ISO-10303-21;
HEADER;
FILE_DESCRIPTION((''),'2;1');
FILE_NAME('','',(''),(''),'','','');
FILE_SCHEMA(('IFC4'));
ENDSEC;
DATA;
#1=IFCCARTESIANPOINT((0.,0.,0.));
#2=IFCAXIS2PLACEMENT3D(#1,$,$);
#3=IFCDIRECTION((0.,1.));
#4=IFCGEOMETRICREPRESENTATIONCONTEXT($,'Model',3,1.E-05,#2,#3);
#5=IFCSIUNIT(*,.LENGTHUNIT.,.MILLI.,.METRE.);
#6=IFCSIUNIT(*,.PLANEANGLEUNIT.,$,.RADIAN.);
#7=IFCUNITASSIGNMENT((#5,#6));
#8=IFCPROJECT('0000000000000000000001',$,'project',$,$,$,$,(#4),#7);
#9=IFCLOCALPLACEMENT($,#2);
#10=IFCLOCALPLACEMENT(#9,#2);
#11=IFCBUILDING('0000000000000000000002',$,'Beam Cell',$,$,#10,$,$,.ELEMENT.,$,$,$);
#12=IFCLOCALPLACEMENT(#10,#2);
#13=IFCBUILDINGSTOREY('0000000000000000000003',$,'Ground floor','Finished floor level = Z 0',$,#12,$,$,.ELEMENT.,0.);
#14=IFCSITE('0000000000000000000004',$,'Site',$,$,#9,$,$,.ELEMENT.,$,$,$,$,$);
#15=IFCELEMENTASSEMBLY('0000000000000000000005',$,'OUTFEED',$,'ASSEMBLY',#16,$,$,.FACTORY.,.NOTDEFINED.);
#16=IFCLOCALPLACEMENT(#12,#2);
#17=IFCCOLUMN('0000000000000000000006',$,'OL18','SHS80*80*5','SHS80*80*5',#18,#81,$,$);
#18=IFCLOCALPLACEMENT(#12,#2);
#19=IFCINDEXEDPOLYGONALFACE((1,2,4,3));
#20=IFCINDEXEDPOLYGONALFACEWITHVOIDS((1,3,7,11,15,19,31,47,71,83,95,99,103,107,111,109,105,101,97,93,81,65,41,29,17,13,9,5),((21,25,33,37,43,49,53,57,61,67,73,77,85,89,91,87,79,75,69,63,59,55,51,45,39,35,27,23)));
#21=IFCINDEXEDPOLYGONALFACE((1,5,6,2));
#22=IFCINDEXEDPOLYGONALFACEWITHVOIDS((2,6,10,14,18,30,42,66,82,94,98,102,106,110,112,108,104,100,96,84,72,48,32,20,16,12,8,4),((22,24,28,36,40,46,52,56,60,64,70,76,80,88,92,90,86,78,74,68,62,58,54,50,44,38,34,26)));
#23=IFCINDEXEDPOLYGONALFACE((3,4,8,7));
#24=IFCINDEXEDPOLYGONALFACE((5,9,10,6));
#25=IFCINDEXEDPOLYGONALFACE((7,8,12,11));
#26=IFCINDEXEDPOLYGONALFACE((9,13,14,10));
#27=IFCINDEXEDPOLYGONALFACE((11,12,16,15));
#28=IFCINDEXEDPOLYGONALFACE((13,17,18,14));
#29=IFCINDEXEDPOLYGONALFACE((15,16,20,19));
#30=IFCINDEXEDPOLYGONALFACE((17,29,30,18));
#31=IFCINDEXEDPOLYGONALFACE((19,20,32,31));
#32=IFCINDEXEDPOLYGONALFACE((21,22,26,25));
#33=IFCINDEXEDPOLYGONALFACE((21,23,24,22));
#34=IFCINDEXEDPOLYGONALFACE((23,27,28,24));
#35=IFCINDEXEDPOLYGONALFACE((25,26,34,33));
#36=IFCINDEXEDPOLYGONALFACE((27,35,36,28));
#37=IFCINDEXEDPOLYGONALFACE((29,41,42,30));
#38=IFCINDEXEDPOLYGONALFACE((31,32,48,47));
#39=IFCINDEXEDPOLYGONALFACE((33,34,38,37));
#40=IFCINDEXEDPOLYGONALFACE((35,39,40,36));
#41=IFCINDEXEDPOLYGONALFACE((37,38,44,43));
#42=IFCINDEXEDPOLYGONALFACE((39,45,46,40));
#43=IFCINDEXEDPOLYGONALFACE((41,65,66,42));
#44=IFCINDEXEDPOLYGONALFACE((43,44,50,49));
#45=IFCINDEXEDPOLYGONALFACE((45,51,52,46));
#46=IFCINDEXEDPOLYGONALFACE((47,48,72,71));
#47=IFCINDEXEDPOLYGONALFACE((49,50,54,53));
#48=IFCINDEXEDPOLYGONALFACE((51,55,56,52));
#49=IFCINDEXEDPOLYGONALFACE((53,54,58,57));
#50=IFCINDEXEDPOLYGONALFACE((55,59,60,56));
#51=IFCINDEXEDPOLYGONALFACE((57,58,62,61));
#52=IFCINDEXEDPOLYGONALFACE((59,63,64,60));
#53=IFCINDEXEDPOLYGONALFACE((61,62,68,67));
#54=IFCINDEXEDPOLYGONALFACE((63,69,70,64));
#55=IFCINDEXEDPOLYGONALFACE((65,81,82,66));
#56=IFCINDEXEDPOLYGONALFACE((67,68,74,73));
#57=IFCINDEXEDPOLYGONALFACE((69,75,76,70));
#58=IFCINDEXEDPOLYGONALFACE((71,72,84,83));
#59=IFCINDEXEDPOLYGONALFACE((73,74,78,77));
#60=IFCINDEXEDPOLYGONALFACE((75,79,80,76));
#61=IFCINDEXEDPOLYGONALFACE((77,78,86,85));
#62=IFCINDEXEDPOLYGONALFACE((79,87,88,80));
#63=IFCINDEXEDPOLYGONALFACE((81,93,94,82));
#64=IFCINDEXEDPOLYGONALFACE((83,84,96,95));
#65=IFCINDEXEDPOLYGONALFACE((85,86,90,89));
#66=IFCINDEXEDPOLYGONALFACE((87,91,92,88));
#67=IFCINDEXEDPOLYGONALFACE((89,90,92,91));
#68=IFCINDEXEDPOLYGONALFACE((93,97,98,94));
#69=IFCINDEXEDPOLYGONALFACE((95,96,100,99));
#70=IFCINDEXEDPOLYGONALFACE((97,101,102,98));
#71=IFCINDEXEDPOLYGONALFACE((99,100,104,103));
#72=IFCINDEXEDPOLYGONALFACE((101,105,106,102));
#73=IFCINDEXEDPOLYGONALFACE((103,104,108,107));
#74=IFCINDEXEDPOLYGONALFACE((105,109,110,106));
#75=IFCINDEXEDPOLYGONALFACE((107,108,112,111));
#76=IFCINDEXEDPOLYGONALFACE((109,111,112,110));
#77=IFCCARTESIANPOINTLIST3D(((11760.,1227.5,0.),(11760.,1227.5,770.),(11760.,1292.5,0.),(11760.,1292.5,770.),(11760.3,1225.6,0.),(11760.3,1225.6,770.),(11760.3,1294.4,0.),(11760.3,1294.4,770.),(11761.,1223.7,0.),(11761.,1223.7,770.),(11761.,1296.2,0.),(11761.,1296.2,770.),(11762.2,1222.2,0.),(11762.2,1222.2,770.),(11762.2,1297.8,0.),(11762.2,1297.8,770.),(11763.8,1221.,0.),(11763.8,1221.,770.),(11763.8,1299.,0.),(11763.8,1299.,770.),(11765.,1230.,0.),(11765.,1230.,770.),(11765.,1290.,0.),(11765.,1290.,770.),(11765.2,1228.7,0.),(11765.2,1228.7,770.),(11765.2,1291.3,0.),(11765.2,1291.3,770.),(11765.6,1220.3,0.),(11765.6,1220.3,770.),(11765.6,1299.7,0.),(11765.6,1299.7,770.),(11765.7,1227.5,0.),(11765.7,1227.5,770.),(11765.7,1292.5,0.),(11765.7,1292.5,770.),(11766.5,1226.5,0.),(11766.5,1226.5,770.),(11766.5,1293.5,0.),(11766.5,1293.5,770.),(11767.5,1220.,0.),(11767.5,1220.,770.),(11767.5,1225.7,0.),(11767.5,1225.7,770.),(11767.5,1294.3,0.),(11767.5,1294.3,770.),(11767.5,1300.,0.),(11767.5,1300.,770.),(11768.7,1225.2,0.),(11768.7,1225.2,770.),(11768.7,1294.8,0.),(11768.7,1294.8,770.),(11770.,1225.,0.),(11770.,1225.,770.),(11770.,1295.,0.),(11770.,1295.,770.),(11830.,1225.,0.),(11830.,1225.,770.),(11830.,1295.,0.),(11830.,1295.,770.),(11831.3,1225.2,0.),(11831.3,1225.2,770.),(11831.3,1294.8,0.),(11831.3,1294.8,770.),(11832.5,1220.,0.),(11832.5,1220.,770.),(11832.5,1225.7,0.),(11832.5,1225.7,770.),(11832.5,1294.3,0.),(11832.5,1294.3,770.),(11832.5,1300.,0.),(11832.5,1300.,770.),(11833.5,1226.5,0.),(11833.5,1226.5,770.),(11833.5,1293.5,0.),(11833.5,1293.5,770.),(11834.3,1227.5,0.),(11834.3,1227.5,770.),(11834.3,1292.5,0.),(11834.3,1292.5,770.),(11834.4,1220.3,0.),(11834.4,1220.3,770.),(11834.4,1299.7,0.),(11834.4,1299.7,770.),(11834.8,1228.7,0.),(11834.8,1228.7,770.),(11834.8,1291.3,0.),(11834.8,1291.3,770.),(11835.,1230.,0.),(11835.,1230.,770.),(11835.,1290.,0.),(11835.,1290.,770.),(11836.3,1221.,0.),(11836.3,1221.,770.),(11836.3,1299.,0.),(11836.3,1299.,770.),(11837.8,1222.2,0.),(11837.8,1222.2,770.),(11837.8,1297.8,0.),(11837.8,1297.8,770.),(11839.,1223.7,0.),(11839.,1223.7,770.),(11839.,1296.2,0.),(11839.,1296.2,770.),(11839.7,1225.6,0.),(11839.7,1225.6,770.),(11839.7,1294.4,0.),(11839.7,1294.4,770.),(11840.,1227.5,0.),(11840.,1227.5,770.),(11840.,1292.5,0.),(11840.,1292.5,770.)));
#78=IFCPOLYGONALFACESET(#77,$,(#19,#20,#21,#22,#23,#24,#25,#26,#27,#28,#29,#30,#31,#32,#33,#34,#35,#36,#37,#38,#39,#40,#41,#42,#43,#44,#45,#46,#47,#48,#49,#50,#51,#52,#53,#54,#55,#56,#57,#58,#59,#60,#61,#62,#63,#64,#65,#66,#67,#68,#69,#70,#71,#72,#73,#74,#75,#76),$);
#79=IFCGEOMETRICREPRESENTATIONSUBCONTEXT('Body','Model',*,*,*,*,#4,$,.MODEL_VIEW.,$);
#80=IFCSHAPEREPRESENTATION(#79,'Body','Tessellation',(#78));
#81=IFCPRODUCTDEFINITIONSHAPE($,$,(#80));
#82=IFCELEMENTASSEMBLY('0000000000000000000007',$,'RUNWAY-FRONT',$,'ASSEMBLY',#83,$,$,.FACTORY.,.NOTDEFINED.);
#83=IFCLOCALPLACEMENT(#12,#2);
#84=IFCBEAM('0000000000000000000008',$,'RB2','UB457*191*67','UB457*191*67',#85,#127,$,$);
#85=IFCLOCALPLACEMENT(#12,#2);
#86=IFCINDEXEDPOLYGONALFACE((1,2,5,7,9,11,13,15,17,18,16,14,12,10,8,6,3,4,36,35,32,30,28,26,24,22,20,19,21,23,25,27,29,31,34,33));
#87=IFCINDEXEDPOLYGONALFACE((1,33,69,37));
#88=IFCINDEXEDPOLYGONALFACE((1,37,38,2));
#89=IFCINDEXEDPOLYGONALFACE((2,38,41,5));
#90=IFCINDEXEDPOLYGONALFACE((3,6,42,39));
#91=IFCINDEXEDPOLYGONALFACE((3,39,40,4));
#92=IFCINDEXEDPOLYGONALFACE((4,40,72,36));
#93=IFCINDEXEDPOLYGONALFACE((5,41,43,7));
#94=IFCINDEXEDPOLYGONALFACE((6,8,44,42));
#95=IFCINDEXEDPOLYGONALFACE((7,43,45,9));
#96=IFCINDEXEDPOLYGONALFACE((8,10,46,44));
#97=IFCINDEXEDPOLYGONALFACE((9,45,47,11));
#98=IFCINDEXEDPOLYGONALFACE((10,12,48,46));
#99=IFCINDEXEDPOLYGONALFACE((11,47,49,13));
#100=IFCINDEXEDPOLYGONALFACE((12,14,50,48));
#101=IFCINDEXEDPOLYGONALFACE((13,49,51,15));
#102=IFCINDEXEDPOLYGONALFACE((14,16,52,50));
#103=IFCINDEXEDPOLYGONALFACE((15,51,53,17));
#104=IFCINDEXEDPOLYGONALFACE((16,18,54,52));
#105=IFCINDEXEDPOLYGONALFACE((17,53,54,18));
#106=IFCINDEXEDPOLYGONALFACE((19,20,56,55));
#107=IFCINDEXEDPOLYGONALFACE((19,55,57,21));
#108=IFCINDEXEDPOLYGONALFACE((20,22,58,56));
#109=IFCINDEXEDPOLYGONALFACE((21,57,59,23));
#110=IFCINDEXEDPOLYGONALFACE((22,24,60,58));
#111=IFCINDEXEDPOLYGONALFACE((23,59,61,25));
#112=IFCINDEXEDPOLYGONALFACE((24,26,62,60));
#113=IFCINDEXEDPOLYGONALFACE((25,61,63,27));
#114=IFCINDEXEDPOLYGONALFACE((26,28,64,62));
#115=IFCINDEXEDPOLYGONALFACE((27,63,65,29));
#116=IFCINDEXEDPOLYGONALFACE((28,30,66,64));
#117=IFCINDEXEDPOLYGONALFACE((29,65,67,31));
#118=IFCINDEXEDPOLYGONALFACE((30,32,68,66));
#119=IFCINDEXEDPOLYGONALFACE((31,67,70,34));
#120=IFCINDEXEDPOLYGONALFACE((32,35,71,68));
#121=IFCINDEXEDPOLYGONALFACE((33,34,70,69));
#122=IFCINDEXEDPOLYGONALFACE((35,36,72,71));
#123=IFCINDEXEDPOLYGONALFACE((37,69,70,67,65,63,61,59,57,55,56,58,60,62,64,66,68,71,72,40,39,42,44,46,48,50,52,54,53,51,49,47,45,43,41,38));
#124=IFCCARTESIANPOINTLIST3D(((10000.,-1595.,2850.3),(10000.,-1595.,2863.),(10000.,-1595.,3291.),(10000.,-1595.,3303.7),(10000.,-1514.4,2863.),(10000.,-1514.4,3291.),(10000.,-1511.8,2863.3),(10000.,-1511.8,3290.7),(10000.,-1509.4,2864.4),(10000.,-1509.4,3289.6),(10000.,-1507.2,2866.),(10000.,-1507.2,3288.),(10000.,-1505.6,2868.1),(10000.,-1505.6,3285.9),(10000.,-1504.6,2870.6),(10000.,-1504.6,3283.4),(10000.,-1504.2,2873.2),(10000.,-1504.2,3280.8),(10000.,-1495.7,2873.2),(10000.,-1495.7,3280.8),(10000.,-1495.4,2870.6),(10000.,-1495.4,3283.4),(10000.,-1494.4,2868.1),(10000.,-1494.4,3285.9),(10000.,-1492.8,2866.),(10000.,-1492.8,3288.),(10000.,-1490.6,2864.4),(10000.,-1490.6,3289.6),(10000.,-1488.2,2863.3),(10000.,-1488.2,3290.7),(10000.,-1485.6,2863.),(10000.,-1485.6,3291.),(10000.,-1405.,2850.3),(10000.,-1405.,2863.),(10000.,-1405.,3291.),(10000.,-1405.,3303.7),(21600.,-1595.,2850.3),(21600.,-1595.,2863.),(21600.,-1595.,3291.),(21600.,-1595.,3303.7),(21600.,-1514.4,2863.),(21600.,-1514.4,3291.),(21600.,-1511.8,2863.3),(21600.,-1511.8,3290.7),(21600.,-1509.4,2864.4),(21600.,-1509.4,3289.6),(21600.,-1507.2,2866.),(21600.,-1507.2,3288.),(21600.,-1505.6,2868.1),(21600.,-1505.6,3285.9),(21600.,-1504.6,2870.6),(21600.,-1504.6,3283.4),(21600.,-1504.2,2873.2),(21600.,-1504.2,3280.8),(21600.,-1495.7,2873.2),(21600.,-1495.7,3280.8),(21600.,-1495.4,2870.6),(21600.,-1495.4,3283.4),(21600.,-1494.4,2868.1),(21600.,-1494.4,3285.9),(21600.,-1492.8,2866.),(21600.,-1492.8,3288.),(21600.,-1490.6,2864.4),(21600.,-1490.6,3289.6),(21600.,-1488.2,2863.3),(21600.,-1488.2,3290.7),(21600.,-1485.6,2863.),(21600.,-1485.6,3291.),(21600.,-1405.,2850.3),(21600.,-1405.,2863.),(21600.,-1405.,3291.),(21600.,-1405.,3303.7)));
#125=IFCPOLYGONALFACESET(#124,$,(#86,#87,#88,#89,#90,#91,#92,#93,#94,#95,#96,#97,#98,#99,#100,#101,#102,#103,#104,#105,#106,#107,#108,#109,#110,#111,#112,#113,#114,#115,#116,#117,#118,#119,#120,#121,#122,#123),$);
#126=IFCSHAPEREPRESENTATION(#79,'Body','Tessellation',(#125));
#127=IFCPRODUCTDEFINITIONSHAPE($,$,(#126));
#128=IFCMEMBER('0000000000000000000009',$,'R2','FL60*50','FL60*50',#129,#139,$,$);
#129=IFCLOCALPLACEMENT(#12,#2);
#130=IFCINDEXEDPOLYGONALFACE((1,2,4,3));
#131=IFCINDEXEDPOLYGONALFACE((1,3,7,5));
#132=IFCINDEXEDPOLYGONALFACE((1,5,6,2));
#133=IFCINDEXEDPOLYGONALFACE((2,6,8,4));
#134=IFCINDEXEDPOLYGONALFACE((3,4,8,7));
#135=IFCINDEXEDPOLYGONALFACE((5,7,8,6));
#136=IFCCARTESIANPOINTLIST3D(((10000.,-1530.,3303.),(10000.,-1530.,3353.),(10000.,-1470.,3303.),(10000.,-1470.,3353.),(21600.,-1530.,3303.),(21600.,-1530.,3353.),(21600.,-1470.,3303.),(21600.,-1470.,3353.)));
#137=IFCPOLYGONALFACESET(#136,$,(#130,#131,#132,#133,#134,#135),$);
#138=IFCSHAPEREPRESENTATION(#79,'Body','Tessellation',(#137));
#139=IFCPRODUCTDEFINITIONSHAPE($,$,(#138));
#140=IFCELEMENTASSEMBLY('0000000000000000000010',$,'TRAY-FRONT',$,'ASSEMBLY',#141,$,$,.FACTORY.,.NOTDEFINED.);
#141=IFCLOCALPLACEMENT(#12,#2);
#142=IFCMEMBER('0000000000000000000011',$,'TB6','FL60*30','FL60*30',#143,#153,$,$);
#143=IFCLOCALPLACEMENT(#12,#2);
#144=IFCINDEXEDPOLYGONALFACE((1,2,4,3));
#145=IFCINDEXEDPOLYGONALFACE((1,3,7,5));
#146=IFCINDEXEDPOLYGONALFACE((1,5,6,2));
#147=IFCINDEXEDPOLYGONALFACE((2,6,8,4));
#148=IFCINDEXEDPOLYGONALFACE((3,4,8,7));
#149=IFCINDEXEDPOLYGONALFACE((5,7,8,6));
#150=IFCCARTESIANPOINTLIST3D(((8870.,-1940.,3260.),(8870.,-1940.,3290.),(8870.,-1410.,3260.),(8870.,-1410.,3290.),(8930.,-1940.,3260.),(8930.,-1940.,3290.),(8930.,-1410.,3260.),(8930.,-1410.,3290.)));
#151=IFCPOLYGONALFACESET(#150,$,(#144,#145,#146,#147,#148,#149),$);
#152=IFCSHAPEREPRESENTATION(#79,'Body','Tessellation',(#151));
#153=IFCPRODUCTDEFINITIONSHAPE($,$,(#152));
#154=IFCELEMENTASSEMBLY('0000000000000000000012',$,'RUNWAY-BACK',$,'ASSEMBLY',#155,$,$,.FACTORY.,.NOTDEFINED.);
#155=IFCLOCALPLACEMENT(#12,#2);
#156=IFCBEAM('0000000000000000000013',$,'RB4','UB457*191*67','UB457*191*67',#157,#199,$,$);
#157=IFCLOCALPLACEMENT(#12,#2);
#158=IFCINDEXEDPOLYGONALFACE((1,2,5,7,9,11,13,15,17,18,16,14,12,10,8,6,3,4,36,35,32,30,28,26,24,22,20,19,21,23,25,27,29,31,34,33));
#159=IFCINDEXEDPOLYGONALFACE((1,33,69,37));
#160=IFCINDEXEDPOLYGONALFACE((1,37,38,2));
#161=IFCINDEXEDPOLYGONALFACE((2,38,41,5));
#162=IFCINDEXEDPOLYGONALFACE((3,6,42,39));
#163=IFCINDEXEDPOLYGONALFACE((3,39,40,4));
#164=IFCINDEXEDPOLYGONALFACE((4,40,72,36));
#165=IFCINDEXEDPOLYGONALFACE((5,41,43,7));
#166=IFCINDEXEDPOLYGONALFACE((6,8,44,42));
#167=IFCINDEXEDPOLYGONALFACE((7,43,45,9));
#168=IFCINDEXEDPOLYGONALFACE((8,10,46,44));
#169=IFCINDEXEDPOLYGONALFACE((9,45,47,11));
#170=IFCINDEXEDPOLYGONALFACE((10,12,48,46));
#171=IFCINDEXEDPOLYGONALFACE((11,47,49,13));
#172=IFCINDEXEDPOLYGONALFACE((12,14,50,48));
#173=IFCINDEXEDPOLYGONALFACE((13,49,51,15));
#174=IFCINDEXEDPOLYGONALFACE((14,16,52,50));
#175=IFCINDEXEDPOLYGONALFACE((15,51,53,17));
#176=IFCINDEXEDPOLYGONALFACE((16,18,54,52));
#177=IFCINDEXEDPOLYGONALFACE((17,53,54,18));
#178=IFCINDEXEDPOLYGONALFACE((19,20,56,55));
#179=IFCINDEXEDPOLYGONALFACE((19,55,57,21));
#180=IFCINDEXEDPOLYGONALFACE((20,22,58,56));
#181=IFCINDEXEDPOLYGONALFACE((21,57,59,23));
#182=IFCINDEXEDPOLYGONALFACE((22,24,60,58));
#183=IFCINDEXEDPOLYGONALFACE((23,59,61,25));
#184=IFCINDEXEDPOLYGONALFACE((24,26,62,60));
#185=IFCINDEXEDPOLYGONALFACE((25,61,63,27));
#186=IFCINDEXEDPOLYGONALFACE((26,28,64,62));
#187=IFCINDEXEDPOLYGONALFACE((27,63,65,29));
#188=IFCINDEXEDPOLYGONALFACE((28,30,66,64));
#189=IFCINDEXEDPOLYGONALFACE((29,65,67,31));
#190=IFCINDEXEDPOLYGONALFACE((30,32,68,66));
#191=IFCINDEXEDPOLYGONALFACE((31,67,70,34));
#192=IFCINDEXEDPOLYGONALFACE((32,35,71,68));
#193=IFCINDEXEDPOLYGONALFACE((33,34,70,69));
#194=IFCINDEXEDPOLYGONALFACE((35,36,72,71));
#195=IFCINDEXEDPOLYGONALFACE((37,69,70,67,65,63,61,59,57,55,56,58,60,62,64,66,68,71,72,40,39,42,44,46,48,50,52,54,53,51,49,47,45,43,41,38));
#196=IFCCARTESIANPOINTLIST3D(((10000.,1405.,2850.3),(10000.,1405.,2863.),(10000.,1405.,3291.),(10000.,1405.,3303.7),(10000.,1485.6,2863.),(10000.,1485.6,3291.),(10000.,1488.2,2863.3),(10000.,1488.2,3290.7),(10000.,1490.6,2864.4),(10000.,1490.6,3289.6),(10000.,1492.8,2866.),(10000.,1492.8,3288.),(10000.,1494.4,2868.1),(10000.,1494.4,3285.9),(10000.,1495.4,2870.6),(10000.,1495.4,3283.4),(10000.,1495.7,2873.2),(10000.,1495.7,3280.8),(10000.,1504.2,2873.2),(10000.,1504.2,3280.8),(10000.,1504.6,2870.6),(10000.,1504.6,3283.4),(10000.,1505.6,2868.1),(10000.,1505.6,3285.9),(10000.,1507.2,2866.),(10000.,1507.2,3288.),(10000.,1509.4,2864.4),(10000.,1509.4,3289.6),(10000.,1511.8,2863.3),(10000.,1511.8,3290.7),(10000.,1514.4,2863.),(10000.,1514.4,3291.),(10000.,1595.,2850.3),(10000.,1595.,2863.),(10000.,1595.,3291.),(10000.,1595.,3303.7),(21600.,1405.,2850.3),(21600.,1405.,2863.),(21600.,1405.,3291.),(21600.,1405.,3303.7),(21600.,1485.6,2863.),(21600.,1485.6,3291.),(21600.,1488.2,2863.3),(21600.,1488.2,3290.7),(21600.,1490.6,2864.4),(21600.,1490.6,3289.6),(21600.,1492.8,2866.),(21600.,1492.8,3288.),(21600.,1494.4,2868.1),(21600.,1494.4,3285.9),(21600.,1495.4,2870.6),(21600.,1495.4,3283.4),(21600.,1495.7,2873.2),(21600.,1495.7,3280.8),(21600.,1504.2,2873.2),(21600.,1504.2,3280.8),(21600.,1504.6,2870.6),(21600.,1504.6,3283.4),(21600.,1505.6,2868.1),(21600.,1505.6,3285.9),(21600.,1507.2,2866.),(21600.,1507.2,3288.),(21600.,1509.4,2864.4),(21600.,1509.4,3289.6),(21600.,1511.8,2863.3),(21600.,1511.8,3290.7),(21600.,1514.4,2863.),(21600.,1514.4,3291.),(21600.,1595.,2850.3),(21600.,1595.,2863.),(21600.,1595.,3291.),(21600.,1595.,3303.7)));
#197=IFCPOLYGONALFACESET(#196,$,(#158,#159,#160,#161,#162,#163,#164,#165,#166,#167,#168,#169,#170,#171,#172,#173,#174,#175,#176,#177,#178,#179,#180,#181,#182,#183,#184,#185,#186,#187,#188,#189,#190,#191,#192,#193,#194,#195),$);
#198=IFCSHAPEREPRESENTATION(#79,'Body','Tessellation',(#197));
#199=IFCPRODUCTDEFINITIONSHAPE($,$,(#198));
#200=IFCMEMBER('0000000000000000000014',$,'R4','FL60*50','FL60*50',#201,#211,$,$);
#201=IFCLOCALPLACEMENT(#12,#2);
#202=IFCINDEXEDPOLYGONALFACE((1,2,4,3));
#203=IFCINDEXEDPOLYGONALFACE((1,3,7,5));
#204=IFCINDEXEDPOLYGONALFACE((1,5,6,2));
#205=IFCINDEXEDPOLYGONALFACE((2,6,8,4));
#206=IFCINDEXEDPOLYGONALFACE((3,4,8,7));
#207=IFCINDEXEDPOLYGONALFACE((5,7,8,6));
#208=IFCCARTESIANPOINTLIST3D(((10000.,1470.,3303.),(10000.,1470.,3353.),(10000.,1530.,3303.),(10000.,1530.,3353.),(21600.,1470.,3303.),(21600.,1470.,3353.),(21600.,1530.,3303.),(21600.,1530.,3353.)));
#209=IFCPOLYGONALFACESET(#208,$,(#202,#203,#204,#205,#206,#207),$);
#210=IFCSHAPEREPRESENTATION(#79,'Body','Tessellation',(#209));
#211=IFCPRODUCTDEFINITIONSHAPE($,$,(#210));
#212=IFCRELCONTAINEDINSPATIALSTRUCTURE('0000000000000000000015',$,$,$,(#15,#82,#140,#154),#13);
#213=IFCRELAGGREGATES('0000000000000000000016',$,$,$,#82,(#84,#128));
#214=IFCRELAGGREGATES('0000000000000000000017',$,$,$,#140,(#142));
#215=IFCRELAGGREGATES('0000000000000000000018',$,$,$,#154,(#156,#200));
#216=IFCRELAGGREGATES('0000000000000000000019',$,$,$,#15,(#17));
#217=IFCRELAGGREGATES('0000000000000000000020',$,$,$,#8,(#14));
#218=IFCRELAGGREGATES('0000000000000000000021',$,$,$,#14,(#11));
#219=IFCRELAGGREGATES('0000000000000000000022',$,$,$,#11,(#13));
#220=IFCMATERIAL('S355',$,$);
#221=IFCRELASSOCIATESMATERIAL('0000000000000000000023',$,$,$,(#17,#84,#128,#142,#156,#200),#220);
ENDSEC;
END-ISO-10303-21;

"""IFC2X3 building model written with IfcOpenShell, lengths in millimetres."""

from ifc_helpers import new_model, si_unit, direction, frame, origin, origin_2d, place, context, subcontext, project, spatial, rectangle, hollow_rectangle, i_section, extrude, material, element, aggregate, save


model = new_model("IFC2X3")

# Units and contexts
model_context = context("Model", 3, precision=1e-05, world=origin(), true_north=direction((0.0, 1.0)))
body_context = subcontext(model_context, "Body", "Model", "MODEL_VIEW")
ifc_project = project(units=[si_unit("LENGTHUNIT", "METRE", prefix="MILLI"), si_unit("PLANEANGLEUNIT", "RADIAN")], contexts=[model_context])

# Site, building, storey
site_placement = place(None, origin())
site = spatial("IfcSite", under=ifc_project, at=site_placement, Name="Site", CompositionType="ELEMENT")
building_placement = place(site_placement, origin())
building = spatial("IfcBuilding", under=site, at=building_placement, Name="Beam Cell", CompositionType="ELEMENT")
storey_placement = place(building_placement, origin())
storey = spatial("IfcBuildingStorey", under=building, at=storey_placement, Name="Ground floor", Description="Finished floor level = Z 0", CompositionType="ELEMENT", Elevation=0.0)

# Element assembly, column
ifc_material = material(Name="S355")
assembly_1_placement = place(storey_placement, origin())
assembly_1 = element("IfcElementAssembly", 1, at=assembly_1_placement, inside=storey, Name="OUTFEED", ObjectType="ASSEMBLY", AssemblyPlace="FACTORY", PredefinedType="NOTDEFINED")
column_1_placement = place(storey_placement, frame((11800.0, 1260.0, 0.0), z_axis=(0.0, 0.0, 1.0), x_axis=(1.0, 0.0, 0.0)))
column_1 = element("IfcColumn", 2, at=column_1_placement, material=ifc_material, Name="OL18", Description="SHS80*80*5", ObjectType="SHS80*80*5", context=body_context, shape_type="SweptSolid", body=[
    extrude(hollow_rectangle(XDim=80.0, YDim=80.0, WallThickness=5.0, InnerFilletRadius=5.0, OuterFilletRadius=7.5, at=origin_2d()), origin(), (0.0, 0.0, 1.0), 770.0),
])

# Element assembly, beam, member
assembly_2_placement = place(storey_placement, origin())
assembly_2 = element("IfcElementAssembly", 3, at=assembly_2_placement, inside=storey, Name="RUNWAY-FRONT", ObjectType="ASSEMBLY", AssemblyPlace="FACTORY", PredefinedType="NOTDEFINED")
beam_1_placement = place(storey_placement, frame((10000.0, -1500.0, 3077.0), z_axis=(1.0, 0.0, 0.0), x_axis=(0.0, 1.0, 0.0)))
beam_1 = element("IfcBeam", 4, at=beam_1_placement, material=ifc_material, Name="RB2", Description="UB457*191*67", ObjectType="UB457*191*67", context=body_context, shape_type="SweptSolid", body=[
    extrude(i_section(OverallWidth=189.9, OverallDepth=453.4, WebThickness=8.5, FlangeThickness=12.7, FilletRadius=10.2, at=origin_2d()), origin(), (0.0, 0.0, 1.0), 11600.0),
])
member_1_placement = place(storey_placement, frame((10000.0, -1500.0, 3328.0), z_axis=(1.0, 0.0, 0.0), x_axis=(0.0, 1.0, 0.0)))
member_1 = element("IfcMember", 5, at=member_1_placement, material=ifc_material, Name="R2", Description="FL60*50", ObjectType="FL60*50", context=body_context, shape_type="SweptSolid", body=[
    extrude(rectangle(XDim=60.0, YDim=50.0, at=origin_2d()), origin(), (0.0, 0.0, 1.0), 11600.0),
])
aggregate(assembly_2, [beam_1, member_1])

# Element assembly, member
assembly_3_placement = place(storey_placement, origin())
assembly_3 = element("IfcElementAssembly", 6, at=assembly_3_placement, inside=storey, Name="TRAY-FRONT", ObjectType="ASSEMBLY", AssemblyPlace="FACTORY", PredefinedType="NOTDEFINED")
member_2_placement = place(storey_placement, frame((8900.0, -1940.0, 3275.0), z_axis=(0.0, 1.0, 0.0), x_axis=(1.0, 0.0, 0.0)))
member_2 = element("IfcMember", 7, at=member_2_placement, material=ifc_material, Name="TB6", Description="FL60*30", ObjectType="FL60*30", context=body_context, shape_type="SweptSolid", body=[
    extrude(rectangle(XDim=60.0, YDim=30.0, at=origin_2d()), origin(), (0.0, 0.0, 1.0), 530.0),
])
aggregate(assembly_3, [member_2])

# Element assembly, beam, member
assembly_4_placement = place(storey_placement, origin())
assembly_4 = element("IfcElementAssembly", 8, at=assembly_4_placement, inside=storey, Name="RUNWAY-BACK", ObjectType="ASSEMBLY", AssemblyPlace="FACTORY", PredefinedType="NOTDEFINED")
beam_2_placement = place(storey_placement, frame((10000.0, 1500.0, 3077.0), z_axis=(1.0, 0.0, 0.0), x_axis=(0.0, 1.0, 0.0)))
beam_2 = element("IfcBeam", 9, at=beam_2_placement, material=ifc_material, Name="RB4", Description="UB457*191*67", ObjectType="UB457*191*67", context=body_context, shape_type="SweptSolid", body=[
    extrude(i_section(OverallWidth=189.9, OverallDepth=453.4, WebThickness=8.5, FlangeThickness=12.7, FilletRadius=10.2, at=origin_2d()), origin(), (0.0, 0.0, 1.0), 11600.0),
])
member_3_placement = place(storey_placement, frame((10000.0, 1500.0, 3328.0), z_axis=(1.0, 0.0, 0.0), x_axis=(0.0, 1.0, 0.0)))
member_3 = element("IfcMember", 10, at=member_3_placement, material=ifc_material, Name="R4", Description="FL60*50", ObjectType="FL60*50", context=body_context, shape_type="SweptSolid", body=[
    extrude(rectangle(XDim=60.0, YDim=50.0, at=origin_2d()), origin(), (0.0, 0.0, 1.0), 11600.0),
])
aggregate(assembly_4, [beam_2, member_3])

aggregate(assembly_1, [column_1])

save(model, "model.ifc")
